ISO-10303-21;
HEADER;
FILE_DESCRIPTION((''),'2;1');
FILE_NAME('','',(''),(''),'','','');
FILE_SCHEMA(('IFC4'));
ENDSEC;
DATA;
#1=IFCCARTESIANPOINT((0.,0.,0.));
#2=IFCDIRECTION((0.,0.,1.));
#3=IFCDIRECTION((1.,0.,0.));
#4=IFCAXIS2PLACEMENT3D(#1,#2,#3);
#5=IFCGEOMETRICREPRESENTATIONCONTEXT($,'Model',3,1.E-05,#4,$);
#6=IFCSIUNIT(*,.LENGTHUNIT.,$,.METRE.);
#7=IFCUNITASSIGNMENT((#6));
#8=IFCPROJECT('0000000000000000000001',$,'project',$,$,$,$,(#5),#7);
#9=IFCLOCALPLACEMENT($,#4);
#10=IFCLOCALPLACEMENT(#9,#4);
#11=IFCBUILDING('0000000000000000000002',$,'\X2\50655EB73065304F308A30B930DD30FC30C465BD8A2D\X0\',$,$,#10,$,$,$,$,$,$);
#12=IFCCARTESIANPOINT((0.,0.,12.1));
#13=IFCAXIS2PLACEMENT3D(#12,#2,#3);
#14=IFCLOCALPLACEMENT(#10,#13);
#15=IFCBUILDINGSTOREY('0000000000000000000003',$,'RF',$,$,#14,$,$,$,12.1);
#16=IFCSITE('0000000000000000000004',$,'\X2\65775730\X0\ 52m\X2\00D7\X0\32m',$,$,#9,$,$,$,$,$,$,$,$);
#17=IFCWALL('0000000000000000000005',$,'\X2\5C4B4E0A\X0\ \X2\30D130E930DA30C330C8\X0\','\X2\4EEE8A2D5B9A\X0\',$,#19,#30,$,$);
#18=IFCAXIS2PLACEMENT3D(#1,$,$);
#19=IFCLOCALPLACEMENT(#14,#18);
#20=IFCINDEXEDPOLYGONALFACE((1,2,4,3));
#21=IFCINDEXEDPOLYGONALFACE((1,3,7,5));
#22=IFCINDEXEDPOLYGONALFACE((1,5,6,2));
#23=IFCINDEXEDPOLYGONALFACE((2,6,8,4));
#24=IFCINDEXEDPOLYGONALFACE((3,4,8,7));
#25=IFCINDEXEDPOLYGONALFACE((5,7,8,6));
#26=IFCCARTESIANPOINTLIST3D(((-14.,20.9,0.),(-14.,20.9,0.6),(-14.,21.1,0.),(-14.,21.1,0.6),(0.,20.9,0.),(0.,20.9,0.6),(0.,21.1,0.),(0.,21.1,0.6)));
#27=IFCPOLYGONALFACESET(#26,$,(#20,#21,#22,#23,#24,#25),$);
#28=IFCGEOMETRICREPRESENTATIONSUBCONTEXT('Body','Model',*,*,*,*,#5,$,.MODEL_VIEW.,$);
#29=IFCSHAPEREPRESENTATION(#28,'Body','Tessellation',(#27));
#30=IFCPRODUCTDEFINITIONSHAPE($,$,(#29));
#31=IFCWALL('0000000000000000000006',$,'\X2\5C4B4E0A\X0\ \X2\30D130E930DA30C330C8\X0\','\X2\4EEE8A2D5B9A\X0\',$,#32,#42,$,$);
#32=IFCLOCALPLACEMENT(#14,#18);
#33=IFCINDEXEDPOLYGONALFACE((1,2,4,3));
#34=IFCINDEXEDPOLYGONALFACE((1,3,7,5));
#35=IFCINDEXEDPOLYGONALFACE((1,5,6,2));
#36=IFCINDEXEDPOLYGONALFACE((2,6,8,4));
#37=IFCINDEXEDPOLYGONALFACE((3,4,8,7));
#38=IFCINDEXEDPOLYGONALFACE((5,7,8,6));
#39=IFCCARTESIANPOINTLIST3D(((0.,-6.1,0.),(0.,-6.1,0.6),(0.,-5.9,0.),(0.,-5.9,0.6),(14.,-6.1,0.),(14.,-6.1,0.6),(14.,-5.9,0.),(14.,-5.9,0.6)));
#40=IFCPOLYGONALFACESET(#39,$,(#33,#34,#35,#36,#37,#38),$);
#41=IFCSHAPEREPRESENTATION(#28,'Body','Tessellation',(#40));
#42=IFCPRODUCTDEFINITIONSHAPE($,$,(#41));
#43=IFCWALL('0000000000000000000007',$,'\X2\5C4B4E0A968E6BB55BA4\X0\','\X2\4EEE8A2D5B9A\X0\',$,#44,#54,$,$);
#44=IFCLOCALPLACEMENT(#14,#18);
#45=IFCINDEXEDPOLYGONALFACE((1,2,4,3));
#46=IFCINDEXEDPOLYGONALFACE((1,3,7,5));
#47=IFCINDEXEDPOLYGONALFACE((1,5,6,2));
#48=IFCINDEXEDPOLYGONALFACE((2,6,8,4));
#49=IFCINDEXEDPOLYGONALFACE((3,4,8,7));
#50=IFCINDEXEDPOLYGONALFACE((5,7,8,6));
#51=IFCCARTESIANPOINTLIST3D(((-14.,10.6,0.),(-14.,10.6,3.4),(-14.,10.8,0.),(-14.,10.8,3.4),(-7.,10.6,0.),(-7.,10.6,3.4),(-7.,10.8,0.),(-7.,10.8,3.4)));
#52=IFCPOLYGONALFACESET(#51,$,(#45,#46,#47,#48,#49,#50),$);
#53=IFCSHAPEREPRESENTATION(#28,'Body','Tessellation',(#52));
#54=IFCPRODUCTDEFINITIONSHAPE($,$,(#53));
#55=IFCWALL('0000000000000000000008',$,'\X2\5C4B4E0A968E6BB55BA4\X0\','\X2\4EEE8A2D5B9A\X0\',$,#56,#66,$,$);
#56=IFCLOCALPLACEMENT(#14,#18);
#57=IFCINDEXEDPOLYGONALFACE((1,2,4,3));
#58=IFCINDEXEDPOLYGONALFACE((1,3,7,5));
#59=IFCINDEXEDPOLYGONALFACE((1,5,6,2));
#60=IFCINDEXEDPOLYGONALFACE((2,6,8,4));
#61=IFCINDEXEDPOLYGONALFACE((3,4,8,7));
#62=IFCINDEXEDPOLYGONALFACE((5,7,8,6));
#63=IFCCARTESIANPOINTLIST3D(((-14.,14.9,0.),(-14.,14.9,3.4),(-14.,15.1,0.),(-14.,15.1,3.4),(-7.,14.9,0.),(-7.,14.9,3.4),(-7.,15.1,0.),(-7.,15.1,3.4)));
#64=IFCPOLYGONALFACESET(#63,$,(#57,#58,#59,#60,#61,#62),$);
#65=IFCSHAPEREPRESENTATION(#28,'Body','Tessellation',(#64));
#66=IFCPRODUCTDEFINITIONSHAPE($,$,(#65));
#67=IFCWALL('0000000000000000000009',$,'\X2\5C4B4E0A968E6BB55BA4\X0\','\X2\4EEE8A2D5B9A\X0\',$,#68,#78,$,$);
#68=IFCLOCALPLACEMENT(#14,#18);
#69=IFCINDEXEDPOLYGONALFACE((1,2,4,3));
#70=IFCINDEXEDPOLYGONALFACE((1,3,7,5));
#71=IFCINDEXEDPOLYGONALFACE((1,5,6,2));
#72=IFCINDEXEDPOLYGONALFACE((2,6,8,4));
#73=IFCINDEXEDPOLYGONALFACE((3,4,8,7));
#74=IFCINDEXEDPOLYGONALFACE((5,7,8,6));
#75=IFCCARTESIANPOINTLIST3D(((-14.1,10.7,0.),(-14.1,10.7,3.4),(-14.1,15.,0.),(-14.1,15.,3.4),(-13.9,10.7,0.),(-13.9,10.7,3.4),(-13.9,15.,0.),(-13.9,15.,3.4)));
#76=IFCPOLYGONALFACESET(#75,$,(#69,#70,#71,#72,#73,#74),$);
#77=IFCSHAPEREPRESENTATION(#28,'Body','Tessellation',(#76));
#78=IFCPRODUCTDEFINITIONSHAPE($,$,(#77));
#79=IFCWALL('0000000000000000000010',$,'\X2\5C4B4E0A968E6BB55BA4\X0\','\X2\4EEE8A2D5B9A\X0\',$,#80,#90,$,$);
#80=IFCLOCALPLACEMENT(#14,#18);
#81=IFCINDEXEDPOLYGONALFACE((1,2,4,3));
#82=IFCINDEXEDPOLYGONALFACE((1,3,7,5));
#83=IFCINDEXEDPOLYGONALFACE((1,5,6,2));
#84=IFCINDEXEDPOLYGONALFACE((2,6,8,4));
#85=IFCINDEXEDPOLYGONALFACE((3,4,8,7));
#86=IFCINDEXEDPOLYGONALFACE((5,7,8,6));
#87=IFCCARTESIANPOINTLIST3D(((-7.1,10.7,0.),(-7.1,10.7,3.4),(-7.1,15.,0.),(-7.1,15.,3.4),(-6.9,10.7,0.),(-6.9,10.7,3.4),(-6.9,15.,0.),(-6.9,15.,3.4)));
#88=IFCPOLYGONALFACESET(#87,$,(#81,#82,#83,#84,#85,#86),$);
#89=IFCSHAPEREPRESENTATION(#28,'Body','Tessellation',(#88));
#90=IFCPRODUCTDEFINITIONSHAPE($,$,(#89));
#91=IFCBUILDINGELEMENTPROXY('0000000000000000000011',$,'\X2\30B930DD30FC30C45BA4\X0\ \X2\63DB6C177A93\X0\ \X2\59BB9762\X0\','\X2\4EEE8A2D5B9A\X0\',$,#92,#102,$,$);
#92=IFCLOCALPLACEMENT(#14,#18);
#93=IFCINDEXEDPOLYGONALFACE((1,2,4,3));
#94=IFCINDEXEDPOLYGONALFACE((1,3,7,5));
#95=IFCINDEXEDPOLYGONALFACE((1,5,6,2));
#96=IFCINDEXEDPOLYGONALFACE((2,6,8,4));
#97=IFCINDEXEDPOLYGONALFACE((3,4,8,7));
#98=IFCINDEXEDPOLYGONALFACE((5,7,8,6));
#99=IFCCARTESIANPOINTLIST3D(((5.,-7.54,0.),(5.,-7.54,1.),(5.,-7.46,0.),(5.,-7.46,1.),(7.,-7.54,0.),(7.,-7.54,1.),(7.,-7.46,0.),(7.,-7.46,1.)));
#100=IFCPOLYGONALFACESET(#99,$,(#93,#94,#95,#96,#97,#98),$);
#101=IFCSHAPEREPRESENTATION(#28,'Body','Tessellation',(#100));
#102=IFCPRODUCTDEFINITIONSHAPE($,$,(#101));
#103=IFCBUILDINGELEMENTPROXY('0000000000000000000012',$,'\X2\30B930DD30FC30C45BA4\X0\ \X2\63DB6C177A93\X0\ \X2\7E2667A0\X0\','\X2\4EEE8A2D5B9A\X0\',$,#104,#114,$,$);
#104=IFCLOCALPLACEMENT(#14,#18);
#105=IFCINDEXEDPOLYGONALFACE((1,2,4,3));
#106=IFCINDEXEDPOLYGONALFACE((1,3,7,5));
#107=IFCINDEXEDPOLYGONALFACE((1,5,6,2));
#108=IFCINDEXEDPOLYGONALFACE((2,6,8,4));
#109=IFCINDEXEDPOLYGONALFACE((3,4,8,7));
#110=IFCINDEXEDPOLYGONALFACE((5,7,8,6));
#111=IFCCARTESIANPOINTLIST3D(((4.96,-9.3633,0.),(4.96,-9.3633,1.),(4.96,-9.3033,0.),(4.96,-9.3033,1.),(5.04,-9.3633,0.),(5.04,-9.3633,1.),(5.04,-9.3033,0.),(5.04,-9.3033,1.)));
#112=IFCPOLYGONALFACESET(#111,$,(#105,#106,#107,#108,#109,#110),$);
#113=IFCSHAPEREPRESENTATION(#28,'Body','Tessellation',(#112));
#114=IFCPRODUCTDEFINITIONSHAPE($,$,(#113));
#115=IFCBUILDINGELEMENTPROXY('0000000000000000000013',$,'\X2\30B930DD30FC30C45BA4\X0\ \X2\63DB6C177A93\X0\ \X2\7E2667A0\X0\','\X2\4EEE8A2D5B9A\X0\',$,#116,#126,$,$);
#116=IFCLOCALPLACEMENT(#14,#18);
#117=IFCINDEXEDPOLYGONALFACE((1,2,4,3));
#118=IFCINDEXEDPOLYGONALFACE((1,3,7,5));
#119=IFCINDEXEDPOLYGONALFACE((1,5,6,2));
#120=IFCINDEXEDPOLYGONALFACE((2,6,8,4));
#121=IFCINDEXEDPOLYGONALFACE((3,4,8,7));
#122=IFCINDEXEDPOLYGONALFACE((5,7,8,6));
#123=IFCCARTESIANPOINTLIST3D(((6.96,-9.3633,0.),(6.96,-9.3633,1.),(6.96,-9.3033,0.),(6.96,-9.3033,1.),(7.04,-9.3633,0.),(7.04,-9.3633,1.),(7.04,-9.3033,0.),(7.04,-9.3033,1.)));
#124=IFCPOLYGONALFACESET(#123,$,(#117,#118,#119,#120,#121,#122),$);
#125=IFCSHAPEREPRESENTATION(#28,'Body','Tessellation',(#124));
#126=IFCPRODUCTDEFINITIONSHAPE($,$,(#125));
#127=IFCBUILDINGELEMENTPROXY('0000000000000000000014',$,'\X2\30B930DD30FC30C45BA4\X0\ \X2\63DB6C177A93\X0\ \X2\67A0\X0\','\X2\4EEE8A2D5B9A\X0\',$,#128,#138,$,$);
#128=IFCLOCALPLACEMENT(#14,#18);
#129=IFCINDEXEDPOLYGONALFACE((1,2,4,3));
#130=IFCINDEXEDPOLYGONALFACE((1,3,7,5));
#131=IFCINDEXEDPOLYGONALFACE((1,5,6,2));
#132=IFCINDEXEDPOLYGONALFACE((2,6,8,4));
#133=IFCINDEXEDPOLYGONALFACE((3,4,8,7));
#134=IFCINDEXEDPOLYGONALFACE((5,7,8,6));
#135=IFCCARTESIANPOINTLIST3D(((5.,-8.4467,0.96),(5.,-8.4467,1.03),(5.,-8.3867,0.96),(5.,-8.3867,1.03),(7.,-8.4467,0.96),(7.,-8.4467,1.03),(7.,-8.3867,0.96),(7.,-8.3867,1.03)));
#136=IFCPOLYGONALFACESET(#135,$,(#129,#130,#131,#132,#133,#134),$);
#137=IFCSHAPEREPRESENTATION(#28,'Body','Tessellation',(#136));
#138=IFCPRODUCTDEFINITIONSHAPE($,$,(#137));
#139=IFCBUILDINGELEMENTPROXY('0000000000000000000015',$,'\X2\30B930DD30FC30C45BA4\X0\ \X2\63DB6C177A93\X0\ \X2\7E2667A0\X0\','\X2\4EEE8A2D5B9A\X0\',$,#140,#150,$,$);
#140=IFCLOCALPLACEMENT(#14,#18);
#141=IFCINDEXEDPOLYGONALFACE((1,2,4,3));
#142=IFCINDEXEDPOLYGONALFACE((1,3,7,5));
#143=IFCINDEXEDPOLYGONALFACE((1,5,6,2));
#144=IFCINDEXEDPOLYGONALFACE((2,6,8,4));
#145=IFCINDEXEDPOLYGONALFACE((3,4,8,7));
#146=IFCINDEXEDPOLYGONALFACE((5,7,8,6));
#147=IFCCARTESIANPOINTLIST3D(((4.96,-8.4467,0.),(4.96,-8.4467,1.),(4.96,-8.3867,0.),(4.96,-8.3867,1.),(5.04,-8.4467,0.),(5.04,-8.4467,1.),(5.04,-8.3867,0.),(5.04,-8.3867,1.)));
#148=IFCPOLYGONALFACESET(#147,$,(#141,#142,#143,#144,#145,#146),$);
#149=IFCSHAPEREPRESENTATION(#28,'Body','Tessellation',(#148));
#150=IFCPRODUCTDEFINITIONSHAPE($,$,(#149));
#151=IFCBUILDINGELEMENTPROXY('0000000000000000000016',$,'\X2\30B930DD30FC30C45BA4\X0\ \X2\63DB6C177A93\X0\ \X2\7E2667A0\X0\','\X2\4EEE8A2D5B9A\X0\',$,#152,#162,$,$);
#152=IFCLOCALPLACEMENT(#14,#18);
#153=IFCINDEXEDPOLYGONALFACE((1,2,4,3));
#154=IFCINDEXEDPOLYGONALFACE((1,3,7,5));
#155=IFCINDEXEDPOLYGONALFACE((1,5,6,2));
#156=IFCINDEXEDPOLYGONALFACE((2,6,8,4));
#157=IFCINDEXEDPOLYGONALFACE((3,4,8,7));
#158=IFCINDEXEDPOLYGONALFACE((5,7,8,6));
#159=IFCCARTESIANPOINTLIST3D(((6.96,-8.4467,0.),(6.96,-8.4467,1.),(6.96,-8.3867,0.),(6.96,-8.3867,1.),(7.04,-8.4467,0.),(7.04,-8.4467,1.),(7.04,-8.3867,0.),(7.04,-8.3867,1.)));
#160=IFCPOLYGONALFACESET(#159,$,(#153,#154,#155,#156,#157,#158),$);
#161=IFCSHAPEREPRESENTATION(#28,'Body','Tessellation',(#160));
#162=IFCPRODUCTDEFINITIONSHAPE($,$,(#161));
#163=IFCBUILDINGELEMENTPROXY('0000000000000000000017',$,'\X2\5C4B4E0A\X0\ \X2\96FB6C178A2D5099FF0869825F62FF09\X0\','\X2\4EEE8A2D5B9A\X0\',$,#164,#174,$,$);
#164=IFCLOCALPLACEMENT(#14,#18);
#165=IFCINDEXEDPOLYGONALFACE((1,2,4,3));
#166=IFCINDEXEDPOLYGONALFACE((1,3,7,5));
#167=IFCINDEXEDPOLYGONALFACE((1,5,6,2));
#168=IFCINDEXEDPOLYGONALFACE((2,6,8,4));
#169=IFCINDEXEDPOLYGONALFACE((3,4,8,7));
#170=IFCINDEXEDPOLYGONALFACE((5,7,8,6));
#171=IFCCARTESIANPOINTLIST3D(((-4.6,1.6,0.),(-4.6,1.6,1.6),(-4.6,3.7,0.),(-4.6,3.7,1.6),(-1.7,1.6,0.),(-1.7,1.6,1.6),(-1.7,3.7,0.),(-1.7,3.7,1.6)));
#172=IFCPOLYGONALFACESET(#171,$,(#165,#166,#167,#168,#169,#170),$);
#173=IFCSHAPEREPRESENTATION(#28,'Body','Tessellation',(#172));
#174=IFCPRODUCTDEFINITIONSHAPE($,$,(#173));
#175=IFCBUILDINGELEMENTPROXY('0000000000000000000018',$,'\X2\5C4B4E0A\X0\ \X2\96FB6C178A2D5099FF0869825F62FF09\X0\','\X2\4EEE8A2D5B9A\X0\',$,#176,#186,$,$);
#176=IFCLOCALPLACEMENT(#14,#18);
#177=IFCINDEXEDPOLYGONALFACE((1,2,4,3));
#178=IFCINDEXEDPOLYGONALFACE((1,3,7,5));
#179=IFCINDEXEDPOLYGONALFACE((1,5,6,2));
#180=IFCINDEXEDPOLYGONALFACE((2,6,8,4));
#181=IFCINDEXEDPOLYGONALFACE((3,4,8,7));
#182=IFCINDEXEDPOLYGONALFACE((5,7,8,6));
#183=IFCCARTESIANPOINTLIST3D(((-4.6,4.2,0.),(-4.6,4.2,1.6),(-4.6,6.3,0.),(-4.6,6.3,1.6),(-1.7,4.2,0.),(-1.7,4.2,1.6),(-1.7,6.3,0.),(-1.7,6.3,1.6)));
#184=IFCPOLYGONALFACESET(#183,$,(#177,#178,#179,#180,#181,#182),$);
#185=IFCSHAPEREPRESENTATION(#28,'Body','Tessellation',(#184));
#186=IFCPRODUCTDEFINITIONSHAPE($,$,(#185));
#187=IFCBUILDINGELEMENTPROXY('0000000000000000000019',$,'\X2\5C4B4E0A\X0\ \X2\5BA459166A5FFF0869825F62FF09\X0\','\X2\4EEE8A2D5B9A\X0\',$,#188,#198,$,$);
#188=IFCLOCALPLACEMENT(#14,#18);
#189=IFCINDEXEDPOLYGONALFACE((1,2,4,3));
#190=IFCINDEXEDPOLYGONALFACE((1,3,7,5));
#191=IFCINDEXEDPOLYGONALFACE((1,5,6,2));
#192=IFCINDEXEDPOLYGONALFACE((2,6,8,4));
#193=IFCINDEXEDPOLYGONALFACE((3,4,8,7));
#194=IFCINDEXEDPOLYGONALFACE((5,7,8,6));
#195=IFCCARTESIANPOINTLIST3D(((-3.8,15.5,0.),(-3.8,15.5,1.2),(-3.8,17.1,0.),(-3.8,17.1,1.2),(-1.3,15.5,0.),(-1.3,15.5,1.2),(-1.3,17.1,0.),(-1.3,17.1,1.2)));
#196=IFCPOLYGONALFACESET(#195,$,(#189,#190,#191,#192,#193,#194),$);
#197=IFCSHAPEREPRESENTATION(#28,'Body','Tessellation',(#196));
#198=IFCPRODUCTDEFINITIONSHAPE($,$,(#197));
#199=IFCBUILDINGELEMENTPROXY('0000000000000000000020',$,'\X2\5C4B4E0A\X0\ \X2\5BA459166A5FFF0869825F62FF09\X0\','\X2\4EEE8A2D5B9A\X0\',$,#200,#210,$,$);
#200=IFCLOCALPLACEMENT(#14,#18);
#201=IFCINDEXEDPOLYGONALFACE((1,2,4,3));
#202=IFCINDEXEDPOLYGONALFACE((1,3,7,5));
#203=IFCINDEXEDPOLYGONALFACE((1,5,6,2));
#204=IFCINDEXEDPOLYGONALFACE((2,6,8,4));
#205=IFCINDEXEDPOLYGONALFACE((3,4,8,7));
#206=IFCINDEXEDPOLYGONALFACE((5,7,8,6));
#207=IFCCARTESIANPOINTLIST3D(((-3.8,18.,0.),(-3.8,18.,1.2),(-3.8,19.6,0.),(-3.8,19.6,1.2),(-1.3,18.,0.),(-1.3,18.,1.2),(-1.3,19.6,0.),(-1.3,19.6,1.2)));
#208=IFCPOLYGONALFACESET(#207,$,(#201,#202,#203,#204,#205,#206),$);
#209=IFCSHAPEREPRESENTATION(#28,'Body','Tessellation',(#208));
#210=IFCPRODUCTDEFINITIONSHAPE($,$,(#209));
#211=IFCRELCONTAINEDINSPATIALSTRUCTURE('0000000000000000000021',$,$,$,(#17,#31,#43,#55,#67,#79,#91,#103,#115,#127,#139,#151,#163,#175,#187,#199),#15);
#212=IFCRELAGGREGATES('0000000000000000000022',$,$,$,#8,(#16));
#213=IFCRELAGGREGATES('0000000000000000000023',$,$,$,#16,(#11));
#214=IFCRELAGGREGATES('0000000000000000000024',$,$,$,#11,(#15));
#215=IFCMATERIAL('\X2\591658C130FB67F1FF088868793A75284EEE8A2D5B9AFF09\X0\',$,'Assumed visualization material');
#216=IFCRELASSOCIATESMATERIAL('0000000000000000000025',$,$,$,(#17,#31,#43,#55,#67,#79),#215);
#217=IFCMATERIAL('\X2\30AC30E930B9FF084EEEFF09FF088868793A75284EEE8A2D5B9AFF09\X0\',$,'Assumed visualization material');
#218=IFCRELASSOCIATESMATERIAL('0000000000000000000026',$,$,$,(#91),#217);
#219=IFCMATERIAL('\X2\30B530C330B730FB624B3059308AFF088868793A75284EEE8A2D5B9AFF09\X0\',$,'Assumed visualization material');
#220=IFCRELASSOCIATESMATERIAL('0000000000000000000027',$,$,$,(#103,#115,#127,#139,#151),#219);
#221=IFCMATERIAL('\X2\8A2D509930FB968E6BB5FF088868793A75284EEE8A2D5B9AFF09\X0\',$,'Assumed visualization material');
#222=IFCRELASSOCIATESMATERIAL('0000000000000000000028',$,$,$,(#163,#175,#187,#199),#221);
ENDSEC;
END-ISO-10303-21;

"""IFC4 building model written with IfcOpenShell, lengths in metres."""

from ifc_helpers import new_model, si_unit, frame, origin_with_axes, place, context, subcontext, project, spatial, rectangle, extrude, material, element, save


model = new_model("IFC4")

# Units and contexts
model_context = context("Model", 3, precision=1e-05, world=origin_with_axes())
body_context = subcontext(model_context, "Body", "Model", "MODEL_VIEW")
ifc_project = project(units=[si_unit("LENGTHUNIT", "METRE")], contexts=[model_context])

# Site, building, storey
site_placement = place(None, origin_with_axes())
site = spatial("IfcSite", under=ifc_project, at=site_placement, Name="敷地 52m×32m")
building_placement = place(site_placement, origin_with_axes())
building = spatial("IfcBuilding", under=site, at=building_placement, Name="健康づくりスポーツ施設")
storey_placement = place(building_placement, frame((0.0, 0.0, 12.1), z_axis=(0.0, 0.0, 1.0), x_axis=(1.0, 0.0, 0.0)))
storey = spatial("IfcBuildingStorey", under=building, at=storey_placement, Name="RF", Elevation=12.1)

# Shared definitions
ifc_material_1 = material(Name="外壁・柱（表示用仮設定）", Category="Assumed visualization material")

# Walls
wall_1_placement = place(storey_placement, frame((-7.0, 21.0, 0.0), z_axis=(0.0, 0.0, 1.0), x_axis=(1.0, 0.0, 0.0)))
element("IfcWall", 1, at=wall_1_placement, inside=storey, material=ifc_material_1, Name="屋上 パラペット", Description="仮設定", context=body_context, shape_type="SweptSolid", body=[
    extrude(rectangle(XDim=14.0, YDim=0.2), origin_with_axes(), (0.0, 0.0, 1.0), 0.6),
])
wall_2_placement = place(storey_placement, frame((7.0, -6.0, 0.0), z_axis=(0.0, 0.0, 1.0), x_axis=(1.0, 0.0, 0.0)))
element("IfcWall", 2, at=wall_2_placement, inside=storey, material=ifc_material_1, Name="屋上 パラペット", Description="仮設定", context=body_context, shape_type="SweptSolid", body=[
    extrude(rectangle(XDim=14.0, YDim=0.2), origin_with_axes(), (0.0, 0.0, 1.0), 0.6),
])
for number, where, z_axis, x_axis, name in (
    (3, (-10.5, 10.7, 0.0), (0.0, 0.0, 1.0), (1.0, 0.0, 0.0), "屋上階段室"),
    (4, (-10.5, 15.0, 0.0), (0.0, 0.0, 1.0), (1.0, 0.0, 0.0), "屋上階段室"),
):
    element("IfcWall", number, at=place(storey_placement, frame(where, z_axis=z_axis, x_axis=x_axis)), inside=storey, material=ifc_material_1, Name=name, Description="仮設定", context=body_context, shape_type="SweptSolid", body=[
        extrude(rectangle(XDim=7.0, YDim=0.2), origin_with_axes(), (0.0, 0.0, 1.0), 3.4),
    ])
wall_3_placement = place(storey_placement, frame((-14.0, 12.85, 0.0), z_axis=(0.0, 0.0, 1.0), x_axis=(1.0, 0.0, 0.0)))
element("IfcWall", 5, at=wall_3_placement, inside=storey, material=ifc_material_1, Name="屋上階段室", Description="仮設定", context=body_context, shape_type="SweptSolid", body=[
    extrude(rectangle(XDim=0.2, YDim=4.3), origin_with_axes(), (0.0, 0.0, 1.0), 3.4),
])
wall_4_placement = place(storey_placement, frame((-7.0, 12.85, 0.0), z_axis=(0.0, 0.0, 1.0), x_axis=(1.0, 0.0, 0.0)))
element("IfcWall", 6, at=wall_4_placement, inside=storey, material=ifc_material_1, Name="屋上階段室", Description="仮設定", context=body_context, shape_type="SweptSolid", body=[
    extrude(rectangle(XDim=0.2, YDim=4.3), origin_with_axes(), (0.0, 0.0, 1.0), 3.4),
])

# Building element proxies
ifc_material_2 = material(Name="ガラス（仮）（表示用仮設定）", Category="Assumed visualization material")
proxy_1_placement = place(storey_placement, frame((6.0, -7.5, 0.0), z_axis=(0.0, 0.0, 1.0), x_axis=(1.0, 0.0, 0.0)))
element("IfcBuildingElementProxy", 7, at=proxy_1_placement, inside=storey, material=ifc_material_2, Name="スポーツ室 換気窓 妻面", Description="仮設定", context=body_context, shape_type="SweptSolid", body=[
    extrude(rectangle(XDim=2.0, YDim=0.08), origin_with_axes(), (0.0, 0.0, 1.0), 1.0),
])
ifc_material_3 = material(Name="サッシ・手すり（表示用仮設定）", Category="Assumed visualization material")
for number, where, z_axis, x_axis, name in (
    (8, (5.0, -9.3333, 0.0), (0.0, 0.0, 1.0), (1.0, 0.0, 0.0), "スポーツ室 換気窓 縦枠"),
    (9, (7.0, -9.3333, 0.0), (0.0, 0.0, 1.0), (1.0, 0.0, 0.0), "スポーツ室 換気窓 縦枠"),
):
    element("IfcBuildingElementProxy", number, at=place(storey_placement, frame(where, z_axis=z_axis, x_axis=x_axis)), inside=storey, material=ifc_material_3, Name=name, Description="仮設定", context=body_context, shape_type="SweptSolid", body=[
        extrude(rectangle(XDim=0.08, YDim=0.06), origin_with_axes(), (0.0, 0.0, 1.0), 1.0),
    ])
proxy_2_placement = place(storey_placement, frame((6.0, -8.4167, 0.96), z_axis=(0.0, 0.0, 1.0), x_axis=(1.0, 0.0, 0.0)))
element("IfcBuildingElementProxy", 10, at=proxy_2_placement, inside=storey, material=ifc_material_3, Name="スポーツ室 換気窓 枠", Description="仮設定", context=body_context, shape_type="SweptSolid", body=[
    extrude(rectangle(XDim=2.0, YDim=0.06), origin_with_axes(), (0.0, 0.0, 1.0), 0.07),
])
for number, where, z_axis, x_axis, name in (
    (11, (5.0, -8.4167, 0.0), (0.0, 0.0, 1.0), (1.0, 0.0, 0.0), "スポーツ室 換気窓 縦枠"),
    (12, (7.0, -8.4167, 0.0), (0.0, 0.0, 1.0), (1.0, 0.0, 0.0), "スポーツ室 換気窓 縦枠"),
):
    element("IfcBuildingElementProxy", number, at=place(storey_placement, frame(where, z_axis=z_axis, x_axis=x_axis)), inside=storey, material=ifc_material_3, Name=name, Description="仮設定", context=body_context, shape_type="SweptSolid", body=[
        extrude(rectangle(XDim=0.08, YDim=0.06), origin_with_axes(), (0.0, 0.0, 1.0), 1.0),
    ])
ifc_material_4 = material(Name="設備・階段（表示用仮設定）", Category="Assumed visualization material")
for number, where, z_axis, x_axis, name in (
    (13, (-3.15, 2.65, 0.0), (0.0, 0.0, 1.0), (1.0, 0.0, 0.0), "屋上 電気設備（概形）"),
    (14, (-3.15, 5.25, 0.0), (0.0, 0.0, 1.0), (1.0, 0.0, 0.0), "屋上 電気設備（概形）"),
):
    element("IfcBuildingElementProxy", number, at=place(storey_placement, frame(where, z_axis=z_axis, x_axis=x_axis)), inside=storey, material=ifc_material_4, Name=name, Description="仮設定", context=body_context, shape_type="SweptSolid", body=[
        extrude(rectangle(XDim=2.9, YDim=2.1), origin_with_axes(), (0.0, 0.0, 1.0), 1.6),
    ])
for number, where, z_axis, x_axis, name in (
    (15, (-2.55, 16.3, 0.0), (0.0, 0.0, 1.0), (1.0, 0.0, 0.0), "屋上 室外機（概形）"),
    (16, (-2.55, 18.8, 0.0), (0.0, 0.0, 1.0), (1.0, 0.0, 0.0), "屋上 室外機（概形）"),
):
    element("IfcBuildingElementProxy", number, at=place(storey_placement, frame(where, z_axis=z_axis, x_axis=x_axis)), inside=storey, material=ifc_material_4, Name=name, Description="仮設定", context=body_context, shape_type="SweptSolid", body=[
        extrude(rectangle(XDim=2.5, YDim=1.6), origin_with_axes(), (0.0, 0.0, 1.0), 1.2),
    ])

save(model, "model.ifc")
